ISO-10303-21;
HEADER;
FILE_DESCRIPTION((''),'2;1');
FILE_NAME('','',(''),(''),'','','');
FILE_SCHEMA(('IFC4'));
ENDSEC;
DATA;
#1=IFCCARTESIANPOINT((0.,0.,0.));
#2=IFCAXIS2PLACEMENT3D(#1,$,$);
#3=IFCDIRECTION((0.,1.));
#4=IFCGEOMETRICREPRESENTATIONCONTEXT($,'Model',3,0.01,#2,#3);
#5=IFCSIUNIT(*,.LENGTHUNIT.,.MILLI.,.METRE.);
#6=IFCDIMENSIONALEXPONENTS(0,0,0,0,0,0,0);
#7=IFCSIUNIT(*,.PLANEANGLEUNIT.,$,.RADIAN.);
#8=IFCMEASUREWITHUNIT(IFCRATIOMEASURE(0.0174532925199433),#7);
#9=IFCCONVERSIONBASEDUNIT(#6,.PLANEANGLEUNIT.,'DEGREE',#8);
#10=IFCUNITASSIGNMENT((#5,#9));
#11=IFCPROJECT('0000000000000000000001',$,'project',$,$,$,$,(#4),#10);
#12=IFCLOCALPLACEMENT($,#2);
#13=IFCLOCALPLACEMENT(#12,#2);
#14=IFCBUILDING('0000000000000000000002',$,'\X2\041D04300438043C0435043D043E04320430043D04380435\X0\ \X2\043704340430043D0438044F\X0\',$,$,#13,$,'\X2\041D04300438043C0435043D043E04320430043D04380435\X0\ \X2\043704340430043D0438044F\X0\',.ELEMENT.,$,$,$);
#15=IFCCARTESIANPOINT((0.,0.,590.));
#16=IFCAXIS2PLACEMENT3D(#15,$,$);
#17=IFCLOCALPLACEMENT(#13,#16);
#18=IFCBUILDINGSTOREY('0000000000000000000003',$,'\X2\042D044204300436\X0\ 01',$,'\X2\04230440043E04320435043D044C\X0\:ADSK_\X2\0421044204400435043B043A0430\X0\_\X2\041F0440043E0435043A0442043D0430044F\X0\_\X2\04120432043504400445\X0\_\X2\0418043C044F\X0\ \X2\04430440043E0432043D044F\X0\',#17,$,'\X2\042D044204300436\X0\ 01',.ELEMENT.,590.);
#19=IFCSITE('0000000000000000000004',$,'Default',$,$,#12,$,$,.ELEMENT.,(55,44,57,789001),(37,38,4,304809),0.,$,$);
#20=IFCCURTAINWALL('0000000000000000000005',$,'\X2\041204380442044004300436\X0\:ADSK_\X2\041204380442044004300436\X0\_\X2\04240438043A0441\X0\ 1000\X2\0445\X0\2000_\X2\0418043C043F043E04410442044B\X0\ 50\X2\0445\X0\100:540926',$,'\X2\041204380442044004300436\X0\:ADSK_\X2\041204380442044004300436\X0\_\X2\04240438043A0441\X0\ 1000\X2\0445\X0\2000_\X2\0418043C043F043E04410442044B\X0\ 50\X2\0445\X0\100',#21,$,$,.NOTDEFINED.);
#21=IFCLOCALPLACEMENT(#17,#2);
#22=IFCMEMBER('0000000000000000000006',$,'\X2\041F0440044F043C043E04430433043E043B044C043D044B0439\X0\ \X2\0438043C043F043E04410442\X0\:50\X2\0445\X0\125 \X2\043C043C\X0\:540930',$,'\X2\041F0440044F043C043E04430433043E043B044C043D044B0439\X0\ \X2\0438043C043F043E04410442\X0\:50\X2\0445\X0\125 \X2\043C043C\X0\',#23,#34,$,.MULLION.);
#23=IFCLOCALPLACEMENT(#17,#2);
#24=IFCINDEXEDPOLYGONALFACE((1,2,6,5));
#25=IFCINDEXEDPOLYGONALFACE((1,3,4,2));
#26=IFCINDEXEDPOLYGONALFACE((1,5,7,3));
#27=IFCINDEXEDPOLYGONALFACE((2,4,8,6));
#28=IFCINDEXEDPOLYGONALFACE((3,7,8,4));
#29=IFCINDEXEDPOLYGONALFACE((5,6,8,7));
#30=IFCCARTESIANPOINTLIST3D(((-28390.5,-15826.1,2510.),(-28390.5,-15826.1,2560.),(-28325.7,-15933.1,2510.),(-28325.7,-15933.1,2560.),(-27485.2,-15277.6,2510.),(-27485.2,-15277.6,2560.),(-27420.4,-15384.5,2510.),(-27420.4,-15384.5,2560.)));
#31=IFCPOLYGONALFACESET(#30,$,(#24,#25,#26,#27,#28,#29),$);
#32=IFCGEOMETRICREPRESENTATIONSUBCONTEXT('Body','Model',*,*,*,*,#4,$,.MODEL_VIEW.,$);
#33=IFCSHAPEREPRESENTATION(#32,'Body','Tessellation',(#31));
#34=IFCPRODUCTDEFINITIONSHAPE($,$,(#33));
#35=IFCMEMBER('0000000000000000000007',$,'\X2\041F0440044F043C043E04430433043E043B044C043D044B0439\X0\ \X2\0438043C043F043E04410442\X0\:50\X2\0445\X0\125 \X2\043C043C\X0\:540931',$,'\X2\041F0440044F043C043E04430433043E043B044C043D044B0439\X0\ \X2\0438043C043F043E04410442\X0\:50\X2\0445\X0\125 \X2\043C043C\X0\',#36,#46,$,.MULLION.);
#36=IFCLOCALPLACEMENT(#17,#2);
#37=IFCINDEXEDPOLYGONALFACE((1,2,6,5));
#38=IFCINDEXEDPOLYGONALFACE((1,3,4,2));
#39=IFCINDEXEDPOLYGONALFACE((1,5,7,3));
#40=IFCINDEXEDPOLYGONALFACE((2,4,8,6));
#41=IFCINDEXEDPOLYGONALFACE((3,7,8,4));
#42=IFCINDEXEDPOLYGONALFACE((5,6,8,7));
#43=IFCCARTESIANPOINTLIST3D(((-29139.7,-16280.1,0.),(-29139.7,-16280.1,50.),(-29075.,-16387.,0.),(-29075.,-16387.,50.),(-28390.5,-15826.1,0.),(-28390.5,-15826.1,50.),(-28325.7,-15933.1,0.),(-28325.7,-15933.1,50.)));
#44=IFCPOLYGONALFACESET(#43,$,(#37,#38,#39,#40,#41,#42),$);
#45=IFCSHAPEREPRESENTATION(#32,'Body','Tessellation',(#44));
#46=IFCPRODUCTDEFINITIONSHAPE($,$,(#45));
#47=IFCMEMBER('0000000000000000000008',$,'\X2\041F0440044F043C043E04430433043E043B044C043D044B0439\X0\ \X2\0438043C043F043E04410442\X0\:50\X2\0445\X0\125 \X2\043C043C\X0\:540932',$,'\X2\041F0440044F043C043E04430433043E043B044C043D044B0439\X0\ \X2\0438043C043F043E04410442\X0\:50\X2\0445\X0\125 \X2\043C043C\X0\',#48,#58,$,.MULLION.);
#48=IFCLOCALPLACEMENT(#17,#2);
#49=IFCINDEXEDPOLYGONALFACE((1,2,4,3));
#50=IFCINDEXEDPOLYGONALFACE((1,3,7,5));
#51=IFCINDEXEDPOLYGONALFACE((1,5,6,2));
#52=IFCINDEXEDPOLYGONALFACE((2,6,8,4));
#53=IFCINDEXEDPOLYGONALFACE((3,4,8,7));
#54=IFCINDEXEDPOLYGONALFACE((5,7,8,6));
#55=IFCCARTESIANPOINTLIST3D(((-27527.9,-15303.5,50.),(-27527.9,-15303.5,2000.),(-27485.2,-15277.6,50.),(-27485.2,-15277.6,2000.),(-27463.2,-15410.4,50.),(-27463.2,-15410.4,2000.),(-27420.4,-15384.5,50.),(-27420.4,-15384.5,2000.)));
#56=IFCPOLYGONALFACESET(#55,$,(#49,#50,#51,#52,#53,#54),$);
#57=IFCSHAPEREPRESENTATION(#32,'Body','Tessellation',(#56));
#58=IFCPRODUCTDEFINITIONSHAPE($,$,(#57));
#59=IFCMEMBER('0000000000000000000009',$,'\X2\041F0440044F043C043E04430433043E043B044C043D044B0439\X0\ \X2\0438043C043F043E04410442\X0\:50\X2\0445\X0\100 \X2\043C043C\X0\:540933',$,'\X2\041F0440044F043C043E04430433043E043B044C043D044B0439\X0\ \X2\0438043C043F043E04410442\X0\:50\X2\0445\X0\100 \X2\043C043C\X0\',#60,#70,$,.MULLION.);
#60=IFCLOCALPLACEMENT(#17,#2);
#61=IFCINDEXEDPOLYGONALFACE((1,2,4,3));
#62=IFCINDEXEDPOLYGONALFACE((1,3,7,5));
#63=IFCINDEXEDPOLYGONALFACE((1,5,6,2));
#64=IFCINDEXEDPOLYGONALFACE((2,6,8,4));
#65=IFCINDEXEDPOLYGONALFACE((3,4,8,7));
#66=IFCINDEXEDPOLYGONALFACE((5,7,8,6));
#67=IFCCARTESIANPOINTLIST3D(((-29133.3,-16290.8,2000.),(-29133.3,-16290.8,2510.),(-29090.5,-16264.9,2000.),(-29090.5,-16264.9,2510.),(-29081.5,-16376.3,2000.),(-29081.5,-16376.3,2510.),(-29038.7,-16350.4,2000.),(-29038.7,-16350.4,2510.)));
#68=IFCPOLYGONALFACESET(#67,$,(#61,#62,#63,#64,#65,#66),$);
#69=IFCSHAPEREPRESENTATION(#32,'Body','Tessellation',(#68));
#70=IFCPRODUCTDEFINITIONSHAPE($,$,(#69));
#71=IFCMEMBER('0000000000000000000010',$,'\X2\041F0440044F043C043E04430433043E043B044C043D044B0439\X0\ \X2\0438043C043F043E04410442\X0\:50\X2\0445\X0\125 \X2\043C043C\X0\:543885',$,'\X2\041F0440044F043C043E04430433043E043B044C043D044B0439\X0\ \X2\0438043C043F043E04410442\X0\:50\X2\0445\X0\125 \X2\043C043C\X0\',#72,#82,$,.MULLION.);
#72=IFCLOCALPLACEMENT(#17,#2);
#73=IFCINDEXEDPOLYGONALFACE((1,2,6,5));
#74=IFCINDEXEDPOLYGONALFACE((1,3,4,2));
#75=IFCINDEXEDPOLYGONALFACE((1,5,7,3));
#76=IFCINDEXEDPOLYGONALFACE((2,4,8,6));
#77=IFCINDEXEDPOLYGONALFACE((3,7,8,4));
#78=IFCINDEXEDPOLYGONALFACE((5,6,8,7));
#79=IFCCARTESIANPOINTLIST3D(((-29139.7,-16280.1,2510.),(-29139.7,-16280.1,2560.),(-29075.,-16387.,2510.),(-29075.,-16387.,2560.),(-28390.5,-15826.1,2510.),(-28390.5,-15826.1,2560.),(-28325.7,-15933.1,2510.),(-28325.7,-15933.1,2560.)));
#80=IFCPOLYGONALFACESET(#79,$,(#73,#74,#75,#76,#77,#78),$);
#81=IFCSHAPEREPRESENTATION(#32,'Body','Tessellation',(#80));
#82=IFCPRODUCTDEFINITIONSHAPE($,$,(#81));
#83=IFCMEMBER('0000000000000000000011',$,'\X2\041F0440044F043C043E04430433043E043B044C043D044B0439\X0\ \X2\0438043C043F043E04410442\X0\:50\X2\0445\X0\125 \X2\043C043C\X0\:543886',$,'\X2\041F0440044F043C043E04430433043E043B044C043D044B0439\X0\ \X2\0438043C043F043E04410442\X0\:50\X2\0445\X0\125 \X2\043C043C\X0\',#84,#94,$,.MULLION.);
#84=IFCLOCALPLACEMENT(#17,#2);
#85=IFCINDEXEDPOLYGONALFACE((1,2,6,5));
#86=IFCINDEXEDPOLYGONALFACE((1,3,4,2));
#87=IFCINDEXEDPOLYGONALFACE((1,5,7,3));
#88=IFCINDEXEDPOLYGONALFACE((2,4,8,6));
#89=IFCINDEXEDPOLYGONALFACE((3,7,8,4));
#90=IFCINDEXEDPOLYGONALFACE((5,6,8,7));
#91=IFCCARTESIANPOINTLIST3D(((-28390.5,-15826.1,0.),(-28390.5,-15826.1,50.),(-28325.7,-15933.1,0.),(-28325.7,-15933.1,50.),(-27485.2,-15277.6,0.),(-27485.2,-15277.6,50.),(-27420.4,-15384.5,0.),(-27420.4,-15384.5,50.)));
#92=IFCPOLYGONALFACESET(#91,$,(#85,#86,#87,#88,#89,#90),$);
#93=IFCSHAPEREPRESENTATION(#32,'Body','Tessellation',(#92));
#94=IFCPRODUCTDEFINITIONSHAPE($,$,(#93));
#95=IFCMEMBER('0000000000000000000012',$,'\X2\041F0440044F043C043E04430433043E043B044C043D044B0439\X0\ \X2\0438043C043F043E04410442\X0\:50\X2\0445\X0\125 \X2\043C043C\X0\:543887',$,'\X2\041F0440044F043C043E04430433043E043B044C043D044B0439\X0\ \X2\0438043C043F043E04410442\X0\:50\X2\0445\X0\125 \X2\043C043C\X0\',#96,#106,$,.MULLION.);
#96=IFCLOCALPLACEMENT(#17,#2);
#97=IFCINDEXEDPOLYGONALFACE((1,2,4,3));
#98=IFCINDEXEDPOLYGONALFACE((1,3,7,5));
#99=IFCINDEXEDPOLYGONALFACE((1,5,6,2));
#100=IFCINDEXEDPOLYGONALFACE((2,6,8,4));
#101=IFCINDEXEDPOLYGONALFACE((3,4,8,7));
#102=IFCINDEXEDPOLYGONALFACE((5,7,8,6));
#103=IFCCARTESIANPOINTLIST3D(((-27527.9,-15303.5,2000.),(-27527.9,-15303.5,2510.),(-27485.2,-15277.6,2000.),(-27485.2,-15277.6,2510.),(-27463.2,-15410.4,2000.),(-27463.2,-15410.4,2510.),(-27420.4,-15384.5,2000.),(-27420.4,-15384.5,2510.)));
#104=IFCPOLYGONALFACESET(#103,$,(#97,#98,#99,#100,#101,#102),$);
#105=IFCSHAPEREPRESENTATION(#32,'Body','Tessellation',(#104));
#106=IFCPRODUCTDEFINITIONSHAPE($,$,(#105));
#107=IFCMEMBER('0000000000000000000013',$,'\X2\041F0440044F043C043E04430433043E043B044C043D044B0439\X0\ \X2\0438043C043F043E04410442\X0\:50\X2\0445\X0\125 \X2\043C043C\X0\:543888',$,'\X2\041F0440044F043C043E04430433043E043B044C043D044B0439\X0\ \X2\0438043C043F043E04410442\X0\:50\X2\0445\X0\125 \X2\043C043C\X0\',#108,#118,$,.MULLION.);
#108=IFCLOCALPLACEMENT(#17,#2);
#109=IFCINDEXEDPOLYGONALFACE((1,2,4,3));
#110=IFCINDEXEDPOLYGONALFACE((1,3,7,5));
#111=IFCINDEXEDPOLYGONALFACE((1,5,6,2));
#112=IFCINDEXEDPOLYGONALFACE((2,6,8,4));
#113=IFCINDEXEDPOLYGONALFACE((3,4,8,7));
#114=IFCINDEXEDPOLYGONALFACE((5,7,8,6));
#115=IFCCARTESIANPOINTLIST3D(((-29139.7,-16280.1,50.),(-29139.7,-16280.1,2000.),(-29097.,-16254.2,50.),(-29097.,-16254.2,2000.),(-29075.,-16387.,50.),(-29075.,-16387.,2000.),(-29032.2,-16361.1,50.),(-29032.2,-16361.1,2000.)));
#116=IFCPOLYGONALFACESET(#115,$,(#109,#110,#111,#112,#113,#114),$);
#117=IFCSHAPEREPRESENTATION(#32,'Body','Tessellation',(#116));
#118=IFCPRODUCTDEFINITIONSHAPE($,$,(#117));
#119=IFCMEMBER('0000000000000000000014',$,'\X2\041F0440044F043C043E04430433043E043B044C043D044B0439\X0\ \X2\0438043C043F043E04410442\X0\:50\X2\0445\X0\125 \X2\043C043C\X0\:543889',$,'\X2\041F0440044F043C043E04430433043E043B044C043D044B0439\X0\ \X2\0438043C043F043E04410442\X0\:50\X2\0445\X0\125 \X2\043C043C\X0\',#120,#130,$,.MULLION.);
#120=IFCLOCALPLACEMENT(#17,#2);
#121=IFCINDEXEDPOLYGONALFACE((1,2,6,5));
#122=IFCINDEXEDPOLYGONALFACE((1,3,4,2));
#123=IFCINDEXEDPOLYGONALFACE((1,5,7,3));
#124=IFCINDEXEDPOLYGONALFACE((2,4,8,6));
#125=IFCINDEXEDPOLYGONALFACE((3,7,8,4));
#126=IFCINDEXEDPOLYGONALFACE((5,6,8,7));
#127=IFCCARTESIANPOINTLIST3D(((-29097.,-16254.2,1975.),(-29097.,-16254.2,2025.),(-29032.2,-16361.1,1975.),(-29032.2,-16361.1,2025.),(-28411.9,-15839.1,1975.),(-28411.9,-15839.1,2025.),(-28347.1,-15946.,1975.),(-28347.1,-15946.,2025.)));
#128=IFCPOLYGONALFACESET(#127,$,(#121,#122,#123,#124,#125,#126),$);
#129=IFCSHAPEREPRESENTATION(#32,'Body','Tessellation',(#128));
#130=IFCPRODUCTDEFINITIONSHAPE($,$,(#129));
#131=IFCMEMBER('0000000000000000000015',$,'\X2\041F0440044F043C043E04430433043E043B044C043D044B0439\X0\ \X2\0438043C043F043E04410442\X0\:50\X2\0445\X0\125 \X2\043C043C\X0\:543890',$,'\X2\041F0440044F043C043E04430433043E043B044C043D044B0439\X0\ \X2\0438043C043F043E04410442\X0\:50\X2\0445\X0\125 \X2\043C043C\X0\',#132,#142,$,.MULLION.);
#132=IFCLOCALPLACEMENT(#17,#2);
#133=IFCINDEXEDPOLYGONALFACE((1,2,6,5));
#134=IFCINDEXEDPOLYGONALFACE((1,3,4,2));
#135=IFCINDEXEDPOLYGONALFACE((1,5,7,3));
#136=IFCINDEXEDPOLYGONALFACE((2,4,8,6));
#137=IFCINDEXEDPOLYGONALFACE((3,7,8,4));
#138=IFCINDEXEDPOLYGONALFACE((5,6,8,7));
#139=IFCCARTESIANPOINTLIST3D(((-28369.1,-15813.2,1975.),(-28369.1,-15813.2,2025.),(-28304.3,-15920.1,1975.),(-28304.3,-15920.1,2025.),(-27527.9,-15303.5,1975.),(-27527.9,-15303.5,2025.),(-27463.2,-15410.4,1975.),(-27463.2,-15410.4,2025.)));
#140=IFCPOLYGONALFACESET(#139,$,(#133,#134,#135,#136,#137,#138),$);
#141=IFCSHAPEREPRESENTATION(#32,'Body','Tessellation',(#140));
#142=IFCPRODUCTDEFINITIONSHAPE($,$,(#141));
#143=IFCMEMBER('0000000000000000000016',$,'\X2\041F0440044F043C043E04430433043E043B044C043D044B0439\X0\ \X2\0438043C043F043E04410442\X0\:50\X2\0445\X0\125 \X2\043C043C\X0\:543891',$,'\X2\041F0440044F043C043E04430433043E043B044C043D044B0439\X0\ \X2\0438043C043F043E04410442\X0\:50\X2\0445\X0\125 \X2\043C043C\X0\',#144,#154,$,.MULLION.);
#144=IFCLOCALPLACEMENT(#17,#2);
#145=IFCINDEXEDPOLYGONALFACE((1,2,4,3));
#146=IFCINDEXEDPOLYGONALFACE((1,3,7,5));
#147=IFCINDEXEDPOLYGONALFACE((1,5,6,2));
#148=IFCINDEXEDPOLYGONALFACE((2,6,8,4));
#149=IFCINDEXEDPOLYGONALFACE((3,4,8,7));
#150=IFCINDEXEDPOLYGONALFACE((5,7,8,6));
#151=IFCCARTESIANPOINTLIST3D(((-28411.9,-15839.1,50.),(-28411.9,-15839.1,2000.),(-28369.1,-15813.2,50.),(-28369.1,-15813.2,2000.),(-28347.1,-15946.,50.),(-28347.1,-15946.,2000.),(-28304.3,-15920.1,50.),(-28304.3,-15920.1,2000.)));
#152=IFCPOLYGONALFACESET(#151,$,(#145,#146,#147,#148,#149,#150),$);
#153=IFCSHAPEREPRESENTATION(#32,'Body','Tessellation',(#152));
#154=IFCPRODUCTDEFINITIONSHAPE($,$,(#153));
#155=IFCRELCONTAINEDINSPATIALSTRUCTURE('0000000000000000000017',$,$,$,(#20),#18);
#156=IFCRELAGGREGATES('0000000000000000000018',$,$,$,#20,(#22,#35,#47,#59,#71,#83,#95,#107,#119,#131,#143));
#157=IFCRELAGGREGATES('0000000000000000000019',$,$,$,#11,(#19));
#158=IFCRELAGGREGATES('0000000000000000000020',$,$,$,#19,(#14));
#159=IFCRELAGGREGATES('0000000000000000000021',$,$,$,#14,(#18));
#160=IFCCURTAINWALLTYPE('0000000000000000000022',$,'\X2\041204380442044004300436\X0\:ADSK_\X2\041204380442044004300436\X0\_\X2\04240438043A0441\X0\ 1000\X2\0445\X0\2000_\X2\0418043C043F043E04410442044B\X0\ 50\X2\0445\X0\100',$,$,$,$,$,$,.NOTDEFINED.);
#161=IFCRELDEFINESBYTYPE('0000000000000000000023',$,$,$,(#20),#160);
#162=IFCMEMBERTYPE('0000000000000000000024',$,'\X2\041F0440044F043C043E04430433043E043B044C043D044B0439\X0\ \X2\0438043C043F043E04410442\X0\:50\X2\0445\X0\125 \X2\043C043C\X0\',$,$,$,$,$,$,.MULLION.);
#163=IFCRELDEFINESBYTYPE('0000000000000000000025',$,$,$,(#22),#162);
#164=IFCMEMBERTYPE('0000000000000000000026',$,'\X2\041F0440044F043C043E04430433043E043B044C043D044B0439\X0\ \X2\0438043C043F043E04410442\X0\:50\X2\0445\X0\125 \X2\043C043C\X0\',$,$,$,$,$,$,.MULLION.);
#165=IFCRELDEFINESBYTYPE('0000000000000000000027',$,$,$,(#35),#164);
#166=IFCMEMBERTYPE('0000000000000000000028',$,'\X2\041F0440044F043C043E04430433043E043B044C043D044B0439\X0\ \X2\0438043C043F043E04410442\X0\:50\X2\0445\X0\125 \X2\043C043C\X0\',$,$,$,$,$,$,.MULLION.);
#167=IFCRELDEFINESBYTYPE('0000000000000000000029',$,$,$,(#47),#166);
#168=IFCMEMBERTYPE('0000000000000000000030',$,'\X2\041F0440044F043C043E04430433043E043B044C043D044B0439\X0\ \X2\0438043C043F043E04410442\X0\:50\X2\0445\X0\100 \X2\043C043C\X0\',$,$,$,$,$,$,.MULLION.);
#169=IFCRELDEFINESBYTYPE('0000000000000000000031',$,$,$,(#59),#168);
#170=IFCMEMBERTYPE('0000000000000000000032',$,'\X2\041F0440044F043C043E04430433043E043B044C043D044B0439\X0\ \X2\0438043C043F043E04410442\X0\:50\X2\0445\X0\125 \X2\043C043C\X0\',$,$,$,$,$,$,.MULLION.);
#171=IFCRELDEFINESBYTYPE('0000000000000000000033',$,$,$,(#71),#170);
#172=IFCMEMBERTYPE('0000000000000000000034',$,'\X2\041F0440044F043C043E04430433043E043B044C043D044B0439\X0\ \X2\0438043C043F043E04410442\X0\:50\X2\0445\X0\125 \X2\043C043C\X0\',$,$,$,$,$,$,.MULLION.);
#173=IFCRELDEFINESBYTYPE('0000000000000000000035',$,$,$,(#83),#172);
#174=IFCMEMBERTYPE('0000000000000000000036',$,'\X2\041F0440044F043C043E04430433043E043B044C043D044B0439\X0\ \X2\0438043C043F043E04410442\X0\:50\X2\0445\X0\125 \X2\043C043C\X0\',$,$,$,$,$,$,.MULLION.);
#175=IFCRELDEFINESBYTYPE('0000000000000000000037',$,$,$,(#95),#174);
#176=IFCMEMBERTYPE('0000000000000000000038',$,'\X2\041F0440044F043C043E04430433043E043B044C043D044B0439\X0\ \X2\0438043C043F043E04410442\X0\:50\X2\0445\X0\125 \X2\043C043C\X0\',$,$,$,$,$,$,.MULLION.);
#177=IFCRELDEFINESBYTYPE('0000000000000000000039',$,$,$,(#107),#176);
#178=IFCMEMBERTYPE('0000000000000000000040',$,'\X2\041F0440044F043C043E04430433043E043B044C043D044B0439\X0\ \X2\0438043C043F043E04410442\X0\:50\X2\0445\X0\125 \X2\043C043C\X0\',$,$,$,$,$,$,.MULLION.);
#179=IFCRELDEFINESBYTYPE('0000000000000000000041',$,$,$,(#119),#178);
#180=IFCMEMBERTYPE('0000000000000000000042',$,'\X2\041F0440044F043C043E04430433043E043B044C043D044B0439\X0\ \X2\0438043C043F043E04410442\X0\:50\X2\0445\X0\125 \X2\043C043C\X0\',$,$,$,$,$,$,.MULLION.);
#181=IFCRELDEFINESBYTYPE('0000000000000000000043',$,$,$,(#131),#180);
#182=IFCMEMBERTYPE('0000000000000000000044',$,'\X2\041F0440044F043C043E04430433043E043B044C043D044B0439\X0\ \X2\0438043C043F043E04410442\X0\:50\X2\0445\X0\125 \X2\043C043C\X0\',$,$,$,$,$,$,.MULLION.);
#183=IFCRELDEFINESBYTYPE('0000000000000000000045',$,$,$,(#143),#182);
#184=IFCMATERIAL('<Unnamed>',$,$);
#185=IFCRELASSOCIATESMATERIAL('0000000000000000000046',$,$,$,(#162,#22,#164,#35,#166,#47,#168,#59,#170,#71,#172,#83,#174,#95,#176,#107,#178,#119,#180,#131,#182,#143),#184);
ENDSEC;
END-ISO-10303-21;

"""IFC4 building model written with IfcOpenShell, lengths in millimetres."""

from ifc_helpers import new_model, entity, si_unit, converted_unit, direction, frame, origin, place, context, subcontext, project, spatial, indexed_curve, outline, extrude, source, transform, mapped, material, type_object, type_shapes, element, aggregate, save


model = new_model("IFC4")

# Units and contexts
model_context = context("Model", 3, precision=0.01, world=origin(), true_north=direction((0.0, 1.0)))
body_context = subcontext(model_context, "Body", "Model", "MODEL_VIEW")
ifc_project = project(units=[si_unit("LENGTHUNIT", "METRE", prefix="MILLI"), converted_unit("PLANEANGLEUNIT", "DEGREE", entity("IfcRatioMeasure", 0.0174532925199433), si_unit("PLANEANGLEUNIT", "RADIAN"), dimensions=[0, 0, 0, 0, 0, 0, 0])], contexts=[model_context])

# Site, building, storey
site_placement = place(None, origin())
site = spatial("IfcSite", under=ifc_project, at=site_placement, Name="Default", CompositionType="ELEMENT", RefLatitude=(55, 44, 57, 789001), RefLongitude=(37, 38, 4, 304809), RefElevation=0.0)
building_placement = place(site_placement, origin())
building = spatial("IfcBuilding", under=site, at=building_placement, Name="Наименование здания", LongName="Наименование здания", CompositionType="ELEMENT")
storey_placement = place(building_placement, frame((0.0, 0.0, 590.0)))
storey = spatial("IfcBuildingStorey", under=building, at=storey_placement, Name="Этаж 01", ObjectType="Уровень:ADSK_Стрелка_Проектная_Вверх_Имя уровня", LongName="Этаж 01", CompositionType="ELEMENT", Elevation=590.0)

# Curtain wall, members
curtain_wall_type = type_object("IfcCurtainWallType", Name="Витраж:ADSK_Витраж_Фикс 1000х2000_Импосты 50х100", PredefinedType="NOTDEFINED")
curtain_wall_1_placement = place(storey_placement, frame((0.0, 0.0, -590.0)))
curtain_wall_1 = element("IfcCurtainWall", 1, at=curtain_wall_1_placement, inside=storey, type_object=curtain_wall_type, Name="Витраж:ADSK_Витраж_Фикс 1000х2000_Импосты 50х100:540926", ObjectType="Витраж:ADSK_Витраж_Фикс 1000х2000_Импосты 50х100", PredefinedType="NOTDEFINED")
ifc_material_1 = material(Name="<Unnamed>")
member_type_1 = type_object("IfcMemberType", Name="Прямоугольный импост:50х125 мм", PredefinedType="MULLION", material=ifc_material_1)
shared_shape_1 = source(origin(), body_context, "Body", "SweptSolid", [
    extrude(outline(indexed_curve([(-62.5, -25.0), (62.5, -25.0), (62.5, 25.0), (-62.5, 25.0), (-62.5, -25.0)], self_intersect=False)), frame((-25.0, 0.0, -1058.5), z_axis=(0.0, 0.0, 1.0), x_axis=(0.0, -1.0, 0.0)), (0.0, 0.0, 1.0), 1058.5),
])
type_shapes(member_type_1, [shared_shape_1])
member_1_placement = place(storey_placement, frame((-27452.8, -15331.1, 2560.0), z_axis=(0.855267, 0.518188, 0.0), x_axis=(0.0, 0.0, 1.0)))
member_1 = element("IfcMember", 2, at=member_1_placement, type_object=member_type_1, material=ifc_material_1, Name="Прямоугольный импост:50х125 мм:540930", ObjectType="Прямоугольный импост:50х125 мм", PredefinedType="MULLION", context=body_context, shape_type="MappedRepresentation", body=[
    mapped(shared_shape_1, transform((0.0, 0.0, 0.0), scale=1.0)),
])
member_type_2 = type_object("IfcMemberType", Name="Прямоугольный импост:50х125 мм", PredefinedType="MULLION", material=ifc_material_1)
shared_shape_2 = source(origin(), body_context, "Body", "SweptSolid", [
    extrude(outline(indexed_curve([(-62.5, -25.0), (62.5, -25.0), (62.5, 25.0), (-62.5, 25.0), (-62.5, -25.0)], self_intersect=False)), frame((-25.0, 0.0, -876.0), z_axis=(0.0, 0.0, 1.0), x_axis=(0.0, -1.0, 0.0)), (0.0, 0.0, 1.0), 876.0),
])
type_shapes(member_type_2, [shared_shape_2])
member_2_placement = place(storey_placement, frame((-29107.4, -16333.6, 0.0), z_axis=(-0.855267, -0.518188, 0.0), x_axis=(0.0, 0.0, -1.0)))
member_2 = element("IfcMember", 3, at=member_2_placement, type_object=member_type_2, material=ifc_material_1, Name="Прямоугольный импост:50х125 мм:540931", ObjectType="Прямоугольный импост:50х125 мм", PredefinedType="MULLION", context=body_context, shape_type="MappedRepresentation", body=[
    mapped(shared_shape_2, transform((0.0, 0.0, 0.0), scale=1.0)),
])
member_type_3 = type_object("IfcMemberType", Name="Прямоугольный импост:50х125 мм", PredefinedType="MULLION", material=ifc_material_1)
shared_shape_3 = source(origin(), body_context, "Body", "SweptSolid", [
    extrude(outline(indexed_curve([(-62.5, -25.0), (62.5, -25.0), (62.5, 25.0), (-62.5, 25.0), (-62.5, -25.0)], self_intersect=False)), frame((-25.0, 0.0, -1950.0), z_axis=(0.0, 0.0, 1.0), x_axis=(0.0, -1.0, 0.0)), (0.0, 0.0, 1.0), 1950.0),
])
type_shapes(member_type_3, [shared_shape_3])
member_3_placement = place(storey_placement, frame((-27452.8, -15331.1, 50.0), z_axis=(0.0, 0.0, -1.0), x_axis=(0.855267, 0.518188, 0.0)))
member_3 = element("IfcMember", 4, at=member_3_placement, type_object=member_type_3, material=ifc_material_1, Name="Прямоугольный импост:50х125 мм:540932", ObjectType="Прямоугольный импост:50х125 мм", PredefinedType="MULLION", context=body_context, shape_type="MappedRepresentation", body=[
    mapped(shared_shape_3, transform((0.0, 0.0, 0.0), scale=1.0)),
])
member_type_4 = type_object("IfcMemberType", Name="Прямоугольный импост:50х100 мм", PredefinedType="MULLION", material=ifc_material_1)
shared_shape_4 = source(origin(), body_context, "Body", "SweptSolid", [
    extrude(outline(indexed_curve([(-50.0, -25.0), (50.0, -25.0), (50.0, 25.0), (-50.0, 25.0), (-50.0, -25.0)], self_intersect=False)), frame((-25.0, 0.0, -510.0), z_axis=(0.0, 0.0, 1.0), x_axis=(0.0, -1.0, 0.0)), (0.0, 0.0, 1.0), 510.0),
])
type_shapes(member_type_4, [shared_shape_4])
member_4_placement = place(storey_placement, frame((-29107.4, -16333.6, 2510.0), z_axis=(0.0, 0.0, 1.0), x_axis=(-0.855267, -0.518188, 0.0)))
member_4 = element("IfcMember", 5, at=member_4_placement, type_object=member_type_4, material=ifc_material_1, Name="Прямоугольный импост:50х100 мм:540933", ObjectType="Прямоугольный импост:50х100 мм", PredefinedType="MULLION", context=body_context, shape_type="MappedRepresentation", body=[
    mapped(shared_shape_4, transform((0.0, 0.0, 0.0), scale=1.0)),
])
member_type_5 = type_object("IfcMemberType", Name="Прямоугольный импост:50х125 мм", PredefinedType="MULLION", material=ifc_material_1)
shared_shape_5 = source(origin(), body_context, "Body", "SweptSolid", [
    extrude(outline(indexed_curve([(-62.5, -25.0), (62.5, -25.0), (62.5, 25.0), (-62.5, 25.0), (-62.5, -25.0)], self_intersect=False)), frame((-25.0, 0.0, -876.0), z_axis=(0.0, 0.0, 1.0), x_axis=(0.0, -1.0, 0.0)), (0.0, 0.0, 1.0), 876.0),
])
type_shapes(member_type_5, [shared_shape_5])
member_5_placement = place(storey_placement, frame((-28358.1, -15879.6, 2560.0), z_axis=(0.855267, 0.518188, 0.0), x_axis=(0.0, 0.0, 1.0)))
member_5 = element("IfcMember", 6, at=member_5_placement, type_object=member_type_5, material=ifc_material_1, Name="Прямоугольный импост:50х125 мм:543885", ObjectType="Прямоугольный импост:50х125 мм", PredefinedType="MULLION", context=body_context, shape_type="MappedRepresentation", body=[
    mapped(shared_shape_5, transform((0.0, 0.0, 0.0), scale=1.0)),
])
member_type_6 = type_object("IfcMemberType", Name="Прямоугольный импост:50х125 мм", PredefinedType="MULLION", material=ifc_material_1)
shared_shape_6 = source(origin(), body_context, "Body", "SweptSolid", [
    extrude(outline(indexed_curve([(-62.5, -25.0), (62.5, -25.0), (62.5, 25.0), (-62.5, 25.0), (-62.5, -25.0)], self_intersect=False)), frame((-25.0, 0.0, -1058.5), z_axis=(0.0, 0.0, 1.0), x_axis=(0.0, -1.0, 0.0)), (0.0, 0.0, 1.0), 1058.5),
])
type_shapes(member_type_6, [shared_shape_6])
member_6_placement = place(storey_placement, frame((-28358.1, -15879.6, 0.0), z_axis=(-0.855267, -0.518188, 0.0), x_axis=(0.0, 0.0, -1.0)))
member_6 = element("IfcMember", 7, at=member_6_placement, type_object=member_type_6, material=ifc_material_1, Name="Прямоугольный импост:50х125 мм:543886", ObjectType="Прямоугольный импост:50х125 мм", PredefinedType="MULLION", context=body_context, shape_type="MappedRepresentation", body=[
    mapped(shared_shape_6, transform((0.0, 0.0, 0.0), scale=1.0)),
])
member_type_7 = type_object("IfcMemberType", Name="Прямоугольный импост:50х125 мм", PredefinedType="MULLION", material=ifc_material_1)
shared_shape_7 = source(origin(), body_context, "Body", "SweptSolid", [
    extrude(outline(indexed_curve([(-62.5, -25.0), (62.5, -25.0), (62.5, 25.0), (-62.5, 25.0), (-62.5, -25.0)], self_intersect=False)), frame((-25.0, 0.0, -510.0), z_axis=(0.0, 0.0, 1.0), x_axis=(0.0, -1.0, 0.0)), (0.0, 0.0, 1.0), 510.0),
])
type_shapes(member_type_7, [shared_shape_7])
member_7_placement = place(storey_placement, frame((-27452.8, -15331.1, 2000.0), z_axis=(0.0, 0.0, -1.0), x_axis=(0.855267, 0.518188, 0.0)))
member_7 = element("IfcMember", 8, at=member_7_placement, type_object=member_type_7, material=ifc_material_1, Name="Прямоугольный импост:50х125 мм:543887", ObjectType="Прямоугольный импост:50х125 мм", PredefinedType="MULLION", context=body_context, shape_type="MappedRepresentation", body=[
    mapped(shared_shape_7, transform((0.0, 0.0, 0.0), scale=1.0)),
])
member_type_8 = type_object("IfcMemberType", Name="Прямоугольный импост:50х125 мм", PredefinedType="MULLION", material=ifc_material_1)
shared_shape_8 = source(origin(), body_context, "Body", "SweptSolid", [
    extrude(outline(indexed_curve([(-62.5, -25.0), (62.5, -25.0), (62.5, 25.0), (-62.5, 25.0), (-62.5, -25.0)], self_intersect=False)), frame((-25.0, 0.0, -1950.0), z_axis=(0.0, 0.0, 1.0), x_axis=(0.0, -1.0, 0.0)), (0.0, 0.0, 1.0), 1950.0),
])
type_shapes(member_type_8, [shared_shape_8])
member_8_placement = place(storey_placement, frame((-29107.4, -16333.6, 2000.0), z_axis=(0.0, 0.0, 1.0), x_axis=(-0.855267, -0.518188, 0.0)))
member_8 = element("IfcMember", 9, at=member_8_placement, type_object=member_type_8, material=ifc_material_1, Name="Прямоугольный импост:50х125 мм:543888", ObjectType="Прямоугольный импост:50х125 мм", PredefinedType="MULLION", context=body_context, shape_type="MappedRepresentation", body=[
    mapped(shared_shape_8, transform((0.0, 0.0, 0.0), scale=1.0)),
])
member_type_9 = type_object("IfcMemberType", Name="Прямоугольный импост:50х125 мм", PredefinedType="MULLION", material=ifc_material_1)
shared_shape_9 = source(origin(), body_context, "Body", "SweptSolid", [
    extrude(outline(indexed_curve([(-62.5, -25.0), (62.5, -25.0), (62.5, 25.0), (-62.5, 25.0), (-62.5, -25.0)], self_intersect=False)), frame((0.0, 0.0, -801.0), z_axis=(0.0, 0.0, 1.0), x_axis=(0.0, -1.0, 0.0)), (0.0, 0.0, 1.0), 801.0),
])
type_shapes(member_type_9, [shared_shape_9])
member_9_placement = place(storey_placement, frame((-28379.5, -15892.6, 2000.0), z_axis=(0.855267, 0.518188, 0.0), x_axis=(0.0, 0.0, 1.0)))
member_9 = element("IfcMember", 10, at=member_9_placement, type_object=member_type_9, material=ifc_material_1, Name="Прямоугольный импост:50х125 мм:543889", ObjectType="Прямоугольный импост:50х125 мм", PredefinedType="MULLION", context=body_context, shape_type="MappedRepresentation", body=[
    mapped(shared_shape_9, transform((0.0, 0.0, 0.0), scale=1.0)),
])
member_type_10 = type_object("IfcMemberType", Name="Прямоугольный импост:50х125 мм", PredefinedType="MULLION", material=ifc_material_1)
shared_shape_10 = source(origin(), body_context, "Body", "SweptSolid", [
    extrude(outline(indexed_curve([(-62.5, -25.0), (62.5, -25.0), (62.5, 25.0), (-62.5, 25.0), (-62.5, -25.0)], self_intersect=False)), frame((0.0, 0.0, -983.5), z_axis=(0.0, 0.0, 1.0), x_axis=(0.0, -1.0, 0.0)), (0.0, 0.0, 1.0), 983.5),
])
type_shapes(member_type_10, [shared_shape_10])
member_10_placement = place(storey_placement, frame((-27495.5, -15357.0, 2000.0), z_axis=(0.855267, 0.518188, 0.0), x_axis=(0.0, 0.0, 1.0)))
member_10 = element("IfcMember", 11, at=member_10_placement, type_object=member_type_10, material=ifc_material_1, Name="Прямоугольный импост:50х125 мм:543890", ObjectType="Прямоугольный импост:50х125 мм", PredefinedType="MULLION", context=body_context, shape_type="MappedRepresentation", body=[
    mapped(shared_shape_10, transform((0.0, 0.0, 0.0), scale=1.0)),
])
member_type_11 = type_object("IfcMemberType", Name="Прямоугольный импост:50х125 мм", PredefinedType="MULLION", material=ifc_material_1)
shared_shape_11 = source(origin(), body_context, "Body", "SweptSolid", [
    extrude(outline(indexed_curve([(-62.5, -25.0), (62.5, -25.0), (62.5, 25.0), (-62.5, 25.0), (-62.5, -25.0)], self_intersect=False)), frame((0.0, 0.0, -1950.0), z_axis=(0.0, 0.0, 1.0), x_axis=(0.0, -1.0, 0.0)), (0.0, 0.0, 1.0), 1950.0),
])
type_shapes(member_type_11, [shared_shape_11])
member_11_placement = place(storey_placement, frame((-28358.1, -15879.6, 50.0), z_axis=(0.0, 0.0, -1.0), x_axis=(0.855267, 0.518188, 0.0)))
member_11 = element("IfcMember", 12, at=member_11_placement, type_object=member_type_11, material=ifc_material_1, Name="Прямоугольный импост:50х125 мм:543891", ObjectType="Прямоугольный импост:50х125 мм", PredefinedType="MULLION", context=body_context, shape_type="MappedRepresentation", body=[
    mapped(shared_shape_11, transform((0.0, 0.0, 0.0), scale=1.0)),
])

aggregate(curtain_wall_1, [member_1, member_2, member_3, member_4, member_5, member_6, member_7, member_8, member_9, member_10, member_11])

save(model, "model.ifc")
